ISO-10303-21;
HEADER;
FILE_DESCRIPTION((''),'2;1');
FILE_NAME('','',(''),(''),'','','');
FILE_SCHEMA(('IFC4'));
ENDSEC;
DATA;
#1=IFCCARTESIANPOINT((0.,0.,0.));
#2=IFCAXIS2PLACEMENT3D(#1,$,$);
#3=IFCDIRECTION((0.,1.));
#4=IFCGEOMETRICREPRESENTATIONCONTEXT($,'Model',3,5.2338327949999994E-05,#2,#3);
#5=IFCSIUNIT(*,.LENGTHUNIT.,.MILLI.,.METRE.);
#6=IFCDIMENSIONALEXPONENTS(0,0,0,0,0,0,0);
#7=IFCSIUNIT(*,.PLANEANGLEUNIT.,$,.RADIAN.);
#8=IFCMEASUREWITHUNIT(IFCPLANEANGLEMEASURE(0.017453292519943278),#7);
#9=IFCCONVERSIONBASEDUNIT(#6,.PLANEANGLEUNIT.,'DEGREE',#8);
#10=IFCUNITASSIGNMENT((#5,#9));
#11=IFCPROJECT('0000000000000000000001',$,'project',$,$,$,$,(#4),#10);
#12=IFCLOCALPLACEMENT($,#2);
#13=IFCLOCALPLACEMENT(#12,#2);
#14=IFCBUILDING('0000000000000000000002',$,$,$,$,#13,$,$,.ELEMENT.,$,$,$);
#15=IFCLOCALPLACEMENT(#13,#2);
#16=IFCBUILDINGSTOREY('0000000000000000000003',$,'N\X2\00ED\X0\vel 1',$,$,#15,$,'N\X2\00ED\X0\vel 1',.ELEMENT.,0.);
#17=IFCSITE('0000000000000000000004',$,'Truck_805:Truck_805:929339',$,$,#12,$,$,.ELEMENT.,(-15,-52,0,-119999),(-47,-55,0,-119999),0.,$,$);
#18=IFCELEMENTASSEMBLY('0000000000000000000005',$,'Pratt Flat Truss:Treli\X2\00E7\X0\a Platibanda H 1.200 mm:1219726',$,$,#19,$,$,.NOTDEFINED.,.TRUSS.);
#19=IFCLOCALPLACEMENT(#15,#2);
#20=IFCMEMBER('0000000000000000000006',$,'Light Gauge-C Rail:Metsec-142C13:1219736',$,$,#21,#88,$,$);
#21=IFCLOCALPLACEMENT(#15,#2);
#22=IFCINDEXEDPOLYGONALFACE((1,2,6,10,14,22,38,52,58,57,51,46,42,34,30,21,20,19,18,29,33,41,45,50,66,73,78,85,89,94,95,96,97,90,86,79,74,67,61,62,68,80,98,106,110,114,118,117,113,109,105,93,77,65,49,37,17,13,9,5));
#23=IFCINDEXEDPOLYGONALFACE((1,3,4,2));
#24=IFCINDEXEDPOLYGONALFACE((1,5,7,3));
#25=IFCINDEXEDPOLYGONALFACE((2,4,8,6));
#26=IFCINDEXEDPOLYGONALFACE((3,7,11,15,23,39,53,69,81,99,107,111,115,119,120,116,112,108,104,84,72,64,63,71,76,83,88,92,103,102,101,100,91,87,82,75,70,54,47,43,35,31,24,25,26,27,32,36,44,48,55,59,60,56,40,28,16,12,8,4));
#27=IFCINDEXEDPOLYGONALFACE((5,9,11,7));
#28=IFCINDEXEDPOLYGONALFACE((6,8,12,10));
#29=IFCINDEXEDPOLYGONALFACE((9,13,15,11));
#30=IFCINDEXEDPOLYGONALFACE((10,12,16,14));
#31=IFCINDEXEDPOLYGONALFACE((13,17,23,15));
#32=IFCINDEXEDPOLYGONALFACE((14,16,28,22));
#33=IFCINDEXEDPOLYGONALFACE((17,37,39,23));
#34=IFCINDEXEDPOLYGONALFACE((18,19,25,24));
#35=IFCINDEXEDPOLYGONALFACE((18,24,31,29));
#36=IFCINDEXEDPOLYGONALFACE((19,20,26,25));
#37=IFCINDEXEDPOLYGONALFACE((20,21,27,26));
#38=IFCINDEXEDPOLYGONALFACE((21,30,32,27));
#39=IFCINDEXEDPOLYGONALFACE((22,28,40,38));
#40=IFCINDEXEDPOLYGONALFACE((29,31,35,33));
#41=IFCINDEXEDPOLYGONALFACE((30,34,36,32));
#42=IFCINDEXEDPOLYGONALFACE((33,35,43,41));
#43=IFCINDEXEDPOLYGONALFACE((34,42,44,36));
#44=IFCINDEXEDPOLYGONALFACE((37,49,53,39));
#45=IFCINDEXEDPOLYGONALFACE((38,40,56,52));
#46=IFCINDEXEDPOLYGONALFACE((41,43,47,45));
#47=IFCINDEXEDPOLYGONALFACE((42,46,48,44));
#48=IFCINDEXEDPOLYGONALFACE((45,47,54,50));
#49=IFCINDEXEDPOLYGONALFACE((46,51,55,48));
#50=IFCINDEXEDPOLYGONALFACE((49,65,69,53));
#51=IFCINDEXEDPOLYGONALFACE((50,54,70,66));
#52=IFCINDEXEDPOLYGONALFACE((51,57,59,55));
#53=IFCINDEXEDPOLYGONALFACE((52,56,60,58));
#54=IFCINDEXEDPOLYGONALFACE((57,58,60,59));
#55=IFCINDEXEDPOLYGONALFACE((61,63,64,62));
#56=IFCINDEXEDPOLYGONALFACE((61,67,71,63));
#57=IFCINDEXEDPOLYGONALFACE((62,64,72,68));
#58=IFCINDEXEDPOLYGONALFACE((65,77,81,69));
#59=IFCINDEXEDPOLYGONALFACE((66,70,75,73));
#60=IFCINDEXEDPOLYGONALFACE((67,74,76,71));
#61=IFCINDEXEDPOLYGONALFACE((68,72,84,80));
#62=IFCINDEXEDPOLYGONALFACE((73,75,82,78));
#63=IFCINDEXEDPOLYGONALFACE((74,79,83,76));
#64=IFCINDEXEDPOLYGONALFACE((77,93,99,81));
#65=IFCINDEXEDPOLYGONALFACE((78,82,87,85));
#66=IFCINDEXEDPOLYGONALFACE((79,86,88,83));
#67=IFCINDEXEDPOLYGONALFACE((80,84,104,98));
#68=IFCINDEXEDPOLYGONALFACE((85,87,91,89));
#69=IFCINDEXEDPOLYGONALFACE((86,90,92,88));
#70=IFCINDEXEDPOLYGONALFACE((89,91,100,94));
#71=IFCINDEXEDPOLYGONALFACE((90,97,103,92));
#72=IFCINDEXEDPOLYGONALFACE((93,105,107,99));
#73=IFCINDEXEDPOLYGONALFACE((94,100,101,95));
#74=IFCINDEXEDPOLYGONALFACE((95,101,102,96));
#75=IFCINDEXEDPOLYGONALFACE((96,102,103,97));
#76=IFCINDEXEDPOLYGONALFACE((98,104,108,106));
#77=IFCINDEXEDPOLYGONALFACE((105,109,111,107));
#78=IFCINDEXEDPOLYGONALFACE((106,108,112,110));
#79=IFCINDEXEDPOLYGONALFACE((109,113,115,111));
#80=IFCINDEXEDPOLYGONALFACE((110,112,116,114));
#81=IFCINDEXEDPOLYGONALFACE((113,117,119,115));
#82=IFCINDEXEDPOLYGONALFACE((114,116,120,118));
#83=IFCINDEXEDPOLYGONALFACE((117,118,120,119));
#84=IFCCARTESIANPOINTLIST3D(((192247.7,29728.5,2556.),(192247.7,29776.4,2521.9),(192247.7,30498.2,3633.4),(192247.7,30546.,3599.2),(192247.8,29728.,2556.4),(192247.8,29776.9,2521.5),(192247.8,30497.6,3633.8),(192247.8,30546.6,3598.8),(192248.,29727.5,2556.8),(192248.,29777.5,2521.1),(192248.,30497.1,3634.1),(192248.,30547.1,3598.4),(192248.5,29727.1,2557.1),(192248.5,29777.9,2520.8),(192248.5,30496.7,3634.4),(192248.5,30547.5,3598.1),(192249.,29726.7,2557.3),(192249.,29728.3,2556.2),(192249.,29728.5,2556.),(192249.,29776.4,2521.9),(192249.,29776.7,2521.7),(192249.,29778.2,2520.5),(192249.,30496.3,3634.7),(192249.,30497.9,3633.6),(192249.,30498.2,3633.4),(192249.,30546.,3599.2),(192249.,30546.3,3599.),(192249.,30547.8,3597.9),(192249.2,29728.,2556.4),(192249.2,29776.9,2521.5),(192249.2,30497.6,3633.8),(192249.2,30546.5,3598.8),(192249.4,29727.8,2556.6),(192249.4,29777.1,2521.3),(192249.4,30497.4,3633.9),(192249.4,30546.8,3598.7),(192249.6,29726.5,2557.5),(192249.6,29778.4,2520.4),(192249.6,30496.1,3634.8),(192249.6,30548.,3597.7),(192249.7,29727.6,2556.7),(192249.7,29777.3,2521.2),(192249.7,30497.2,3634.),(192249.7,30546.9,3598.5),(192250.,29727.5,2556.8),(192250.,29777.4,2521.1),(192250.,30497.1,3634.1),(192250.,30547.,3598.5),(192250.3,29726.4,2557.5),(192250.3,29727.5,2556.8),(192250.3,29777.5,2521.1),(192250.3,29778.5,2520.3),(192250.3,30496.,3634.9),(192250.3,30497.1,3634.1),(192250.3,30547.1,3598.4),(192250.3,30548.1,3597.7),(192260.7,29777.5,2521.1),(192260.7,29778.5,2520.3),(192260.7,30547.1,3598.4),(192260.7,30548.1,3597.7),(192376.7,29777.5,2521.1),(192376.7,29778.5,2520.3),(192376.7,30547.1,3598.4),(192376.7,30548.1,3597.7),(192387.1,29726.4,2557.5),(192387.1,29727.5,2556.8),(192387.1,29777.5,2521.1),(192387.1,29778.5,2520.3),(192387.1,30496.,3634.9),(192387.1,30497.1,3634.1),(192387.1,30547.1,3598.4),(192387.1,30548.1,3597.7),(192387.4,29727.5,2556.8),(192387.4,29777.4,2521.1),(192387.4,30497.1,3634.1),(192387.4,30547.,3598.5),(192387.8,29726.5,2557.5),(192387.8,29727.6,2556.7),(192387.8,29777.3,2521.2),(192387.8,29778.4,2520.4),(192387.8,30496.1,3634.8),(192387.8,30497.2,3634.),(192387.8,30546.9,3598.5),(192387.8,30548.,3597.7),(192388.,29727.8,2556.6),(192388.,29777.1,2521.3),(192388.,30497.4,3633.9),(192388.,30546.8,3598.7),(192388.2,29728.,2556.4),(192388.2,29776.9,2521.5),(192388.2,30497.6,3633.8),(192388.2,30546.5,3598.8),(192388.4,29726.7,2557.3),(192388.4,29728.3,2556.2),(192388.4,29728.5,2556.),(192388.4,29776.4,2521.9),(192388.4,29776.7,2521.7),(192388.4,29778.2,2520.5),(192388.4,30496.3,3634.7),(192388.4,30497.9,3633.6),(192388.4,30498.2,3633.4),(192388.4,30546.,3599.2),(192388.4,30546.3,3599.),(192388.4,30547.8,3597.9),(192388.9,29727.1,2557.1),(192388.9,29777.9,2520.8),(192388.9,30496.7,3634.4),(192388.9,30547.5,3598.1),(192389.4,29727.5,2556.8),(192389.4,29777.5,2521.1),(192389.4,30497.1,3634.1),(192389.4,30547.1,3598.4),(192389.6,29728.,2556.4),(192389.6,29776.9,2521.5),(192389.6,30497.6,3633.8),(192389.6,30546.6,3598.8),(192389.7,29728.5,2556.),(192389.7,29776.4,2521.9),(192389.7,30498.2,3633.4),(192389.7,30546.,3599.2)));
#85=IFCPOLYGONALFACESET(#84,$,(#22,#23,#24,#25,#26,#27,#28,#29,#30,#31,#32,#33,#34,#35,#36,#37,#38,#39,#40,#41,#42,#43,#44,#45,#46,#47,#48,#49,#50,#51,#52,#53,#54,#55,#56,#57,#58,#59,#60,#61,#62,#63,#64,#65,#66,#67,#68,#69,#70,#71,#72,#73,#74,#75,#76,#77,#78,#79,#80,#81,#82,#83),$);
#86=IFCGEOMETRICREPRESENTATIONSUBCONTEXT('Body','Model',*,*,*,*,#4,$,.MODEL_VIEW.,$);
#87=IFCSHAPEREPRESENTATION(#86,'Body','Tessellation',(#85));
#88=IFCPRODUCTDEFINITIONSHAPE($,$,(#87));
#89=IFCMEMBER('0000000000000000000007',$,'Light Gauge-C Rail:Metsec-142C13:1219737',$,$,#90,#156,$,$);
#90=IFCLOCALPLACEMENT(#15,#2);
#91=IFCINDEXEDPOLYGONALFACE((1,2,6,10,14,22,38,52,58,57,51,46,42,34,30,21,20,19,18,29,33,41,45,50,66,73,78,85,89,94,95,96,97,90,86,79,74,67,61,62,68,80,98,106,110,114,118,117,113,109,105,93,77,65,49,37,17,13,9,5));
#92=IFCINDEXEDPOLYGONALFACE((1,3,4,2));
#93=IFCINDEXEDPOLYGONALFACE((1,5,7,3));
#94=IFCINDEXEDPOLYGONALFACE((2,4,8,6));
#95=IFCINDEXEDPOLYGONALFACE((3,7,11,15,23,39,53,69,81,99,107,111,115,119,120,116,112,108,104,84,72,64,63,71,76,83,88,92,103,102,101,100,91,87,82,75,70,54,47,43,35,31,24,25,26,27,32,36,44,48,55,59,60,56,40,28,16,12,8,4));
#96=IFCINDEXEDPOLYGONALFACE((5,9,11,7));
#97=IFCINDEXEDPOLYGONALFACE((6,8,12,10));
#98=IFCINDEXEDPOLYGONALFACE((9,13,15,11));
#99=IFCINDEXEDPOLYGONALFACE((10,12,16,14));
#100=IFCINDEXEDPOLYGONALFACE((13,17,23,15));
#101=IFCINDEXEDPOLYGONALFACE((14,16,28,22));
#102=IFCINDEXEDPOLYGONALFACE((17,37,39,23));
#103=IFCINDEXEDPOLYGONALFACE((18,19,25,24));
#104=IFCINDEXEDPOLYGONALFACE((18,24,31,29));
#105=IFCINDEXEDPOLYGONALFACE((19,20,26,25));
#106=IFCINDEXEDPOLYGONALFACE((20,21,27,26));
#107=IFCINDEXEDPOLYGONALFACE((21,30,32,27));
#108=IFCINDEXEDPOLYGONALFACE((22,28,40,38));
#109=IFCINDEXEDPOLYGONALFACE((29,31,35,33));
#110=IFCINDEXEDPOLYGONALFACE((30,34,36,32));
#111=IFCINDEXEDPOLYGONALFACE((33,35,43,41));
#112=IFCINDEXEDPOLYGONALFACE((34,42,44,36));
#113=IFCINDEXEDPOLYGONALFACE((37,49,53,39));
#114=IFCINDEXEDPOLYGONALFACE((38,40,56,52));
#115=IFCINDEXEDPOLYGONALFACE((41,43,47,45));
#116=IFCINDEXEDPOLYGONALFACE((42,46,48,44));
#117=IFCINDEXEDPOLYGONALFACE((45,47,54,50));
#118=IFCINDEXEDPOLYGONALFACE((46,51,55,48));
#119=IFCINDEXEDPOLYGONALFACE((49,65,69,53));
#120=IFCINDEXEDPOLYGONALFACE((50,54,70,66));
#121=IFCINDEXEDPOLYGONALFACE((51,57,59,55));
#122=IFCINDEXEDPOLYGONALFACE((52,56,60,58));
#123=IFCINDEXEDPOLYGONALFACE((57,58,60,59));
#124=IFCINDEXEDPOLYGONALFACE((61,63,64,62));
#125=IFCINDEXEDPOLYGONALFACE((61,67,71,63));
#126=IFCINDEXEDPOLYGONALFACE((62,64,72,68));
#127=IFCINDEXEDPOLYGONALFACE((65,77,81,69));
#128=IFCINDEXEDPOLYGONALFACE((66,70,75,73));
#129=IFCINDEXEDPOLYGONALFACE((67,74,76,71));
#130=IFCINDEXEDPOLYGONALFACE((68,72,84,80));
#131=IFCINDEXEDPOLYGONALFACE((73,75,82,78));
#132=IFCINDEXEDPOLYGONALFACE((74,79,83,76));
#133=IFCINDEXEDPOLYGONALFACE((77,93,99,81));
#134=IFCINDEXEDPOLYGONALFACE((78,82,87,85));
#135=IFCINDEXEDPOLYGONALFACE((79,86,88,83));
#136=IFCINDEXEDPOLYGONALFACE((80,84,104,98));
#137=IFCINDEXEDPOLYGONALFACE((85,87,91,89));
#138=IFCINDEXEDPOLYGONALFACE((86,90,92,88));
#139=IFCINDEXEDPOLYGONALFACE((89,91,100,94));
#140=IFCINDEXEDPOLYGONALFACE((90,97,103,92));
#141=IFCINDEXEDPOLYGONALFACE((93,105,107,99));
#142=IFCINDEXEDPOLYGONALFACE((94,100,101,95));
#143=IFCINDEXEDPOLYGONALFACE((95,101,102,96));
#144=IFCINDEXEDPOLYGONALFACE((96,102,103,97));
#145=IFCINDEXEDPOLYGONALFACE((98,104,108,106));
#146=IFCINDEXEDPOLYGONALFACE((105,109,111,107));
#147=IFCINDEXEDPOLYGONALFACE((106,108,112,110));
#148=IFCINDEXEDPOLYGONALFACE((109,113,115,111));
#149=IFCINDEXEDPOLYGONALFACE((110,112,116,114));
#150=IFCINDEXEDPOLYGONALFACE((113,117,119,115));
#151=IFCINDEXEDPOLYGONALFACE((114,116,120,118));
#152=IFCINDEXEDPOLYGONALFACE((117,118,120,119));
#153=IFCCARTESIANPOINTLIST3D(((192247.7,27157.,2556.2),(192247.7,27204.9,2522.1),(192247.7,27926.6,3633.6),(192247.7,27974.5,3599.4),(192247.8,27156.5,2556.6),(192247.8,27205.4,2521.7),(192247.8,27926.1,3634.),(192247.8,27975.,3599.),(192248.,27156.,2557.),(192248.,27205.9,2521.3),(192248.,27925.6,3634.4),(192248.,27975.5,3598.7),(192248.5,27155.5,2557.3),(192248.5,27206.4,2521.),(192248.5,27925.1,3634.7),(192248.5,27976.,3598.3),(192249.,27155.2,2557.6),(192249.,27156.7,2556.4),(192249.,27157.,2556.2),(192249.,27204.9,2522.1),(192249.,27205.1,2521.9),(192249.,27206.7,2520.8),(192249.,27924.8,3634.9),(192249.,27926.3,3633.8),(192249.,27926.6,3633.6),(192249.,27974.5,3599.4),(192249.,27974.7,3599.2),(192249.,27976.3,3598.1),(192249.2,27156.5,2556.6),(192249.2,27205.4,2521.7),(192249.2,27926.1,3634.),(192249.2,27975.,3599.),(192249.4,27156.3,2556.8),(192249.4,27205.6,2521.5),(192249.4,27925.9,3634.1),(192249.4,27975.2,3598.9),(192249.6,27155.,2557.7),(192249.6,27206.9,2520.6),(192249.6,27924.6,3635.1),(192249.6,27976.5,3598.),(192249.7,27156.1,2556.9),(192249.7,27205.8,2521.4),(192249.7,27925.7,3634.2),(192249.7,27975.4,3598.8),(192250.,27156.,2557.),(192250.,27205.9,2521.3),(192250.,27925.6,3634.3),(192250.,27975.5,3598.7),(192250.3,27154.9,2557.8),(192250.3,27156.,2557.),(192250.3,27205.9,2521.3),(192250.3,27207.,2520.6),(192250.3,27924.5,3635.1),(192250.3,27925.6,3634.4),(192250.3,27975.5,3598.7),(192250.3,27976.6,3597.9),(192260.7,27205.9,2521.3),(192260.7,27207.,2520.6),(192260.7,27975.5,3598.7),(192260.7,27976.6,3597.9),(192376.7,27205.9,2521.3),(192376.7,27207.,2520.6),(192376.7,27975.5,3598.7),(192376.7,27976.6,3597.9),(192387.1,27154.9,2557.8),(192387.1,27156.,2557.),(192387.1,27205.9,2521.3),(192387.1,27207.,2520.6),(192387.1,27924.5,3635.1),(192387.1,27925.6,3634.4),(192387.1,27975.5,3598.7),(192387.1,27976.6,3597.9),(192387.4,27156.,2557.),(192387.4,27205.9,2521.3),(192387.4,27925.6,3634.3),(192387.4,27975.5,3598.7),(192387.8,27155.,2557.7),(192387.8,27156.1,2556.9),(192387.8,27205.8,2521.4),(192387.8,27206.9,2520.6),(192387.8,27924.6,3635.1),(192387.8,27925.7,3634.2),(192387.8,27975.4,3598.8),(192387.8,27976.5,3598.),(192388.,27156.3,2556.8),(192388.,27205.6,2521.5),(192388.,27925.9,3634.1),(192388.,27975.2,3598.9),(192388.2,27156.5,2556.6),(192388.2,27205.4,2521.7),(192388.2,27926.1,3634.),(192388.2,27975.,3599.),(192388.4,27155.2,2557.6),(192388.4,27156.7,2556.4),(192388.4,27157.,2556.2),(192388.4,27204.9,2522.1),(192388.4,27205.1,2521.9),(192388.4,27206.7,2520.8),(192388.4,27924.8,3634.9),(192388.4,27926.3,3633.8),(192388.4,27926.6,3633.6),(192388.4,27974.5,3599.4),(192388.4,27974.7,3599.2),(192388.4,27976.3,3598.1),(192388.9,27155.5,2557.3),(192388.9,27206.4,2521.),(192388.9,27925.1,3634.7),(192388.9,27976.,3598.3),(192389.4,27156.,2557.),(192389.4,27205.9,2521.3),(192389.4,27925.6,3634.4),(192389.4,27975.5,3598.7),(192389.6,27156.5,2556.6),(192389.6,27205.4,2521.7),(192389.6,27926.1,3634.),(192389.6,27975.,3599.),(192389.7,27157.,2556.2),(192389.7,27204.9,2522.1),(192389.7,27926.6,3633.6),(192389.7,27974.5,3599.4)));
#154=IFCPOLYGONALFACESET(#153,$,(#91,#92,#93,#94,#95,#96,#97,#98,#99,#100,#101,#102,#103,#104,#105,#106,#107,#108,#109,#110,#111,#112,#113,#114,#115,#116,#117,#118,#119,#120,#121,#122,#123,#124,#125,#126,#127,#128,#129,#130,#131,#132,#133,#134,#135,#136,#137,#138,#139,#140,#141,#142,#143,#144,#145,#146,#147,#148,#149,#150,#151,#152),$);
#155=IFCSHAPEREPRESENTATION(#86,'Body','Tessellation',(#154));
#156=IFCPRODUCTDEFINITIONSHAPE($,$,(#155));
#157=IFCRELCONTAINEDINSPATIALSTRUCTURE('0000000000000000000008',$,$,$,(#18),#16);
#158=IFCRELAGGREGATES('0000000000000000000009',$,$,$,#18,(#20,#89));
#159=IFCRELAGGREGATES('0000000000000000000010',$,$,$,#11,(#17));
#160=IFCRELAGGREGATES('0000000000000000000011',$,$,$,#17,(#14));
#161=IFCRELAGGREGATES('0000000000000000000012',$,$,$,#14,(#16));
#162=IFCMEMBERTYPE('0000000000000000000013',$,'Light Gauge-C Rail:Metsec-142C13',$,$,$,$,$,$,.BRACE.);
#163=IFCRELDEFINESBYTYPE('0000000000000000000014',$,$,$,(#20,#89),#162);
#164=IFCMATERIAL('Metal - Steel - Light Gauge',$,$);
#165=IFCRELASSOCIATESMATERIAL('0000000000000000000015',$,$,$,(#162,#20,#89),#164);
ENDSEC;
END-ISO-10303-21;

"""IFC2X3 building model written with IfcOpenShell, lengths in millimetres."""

from ifc_helpers import new_model, entity, si_unit, converted_unit, direction, frame, frame_2d, origin, place, context, subcontext, project, spatial, polyline, circle_curve, parameter, trimmed, segment, composite_curve, outline, extrude, source, transform, mapped, material, type_object, type_shapes, element, aggregate, save


model = new_model("IFC2X3")

# Units and contexts
model_context = context("Model", 3, precision=5.2338327949999994e-05, world=origin(), true_north=direction((0.0, 1.0)))
body_context = subcontext(model_context, "Body", "Model", "MODEL_VIEW")
ifc_project = project(units=[si_unit("LENGTHUNIT", "METRE", prefix="MILLI"), converted_unit("PLANEANGLEUNIT", "DEGREE", entity("IfcPlaneAngleMeasure", 0.017453292519943278), si_unit("PLANEANGLEUNIT", "RADIAN"), dimensions=[0, 0, 0, 0, 0, 0, 0])], contexts=[model_context])

# Site, building, storey
site_placement = place(None, origin())
site = spatial("IfcSite", under=ifc_project, at=site_placement, Name="Truck_805:Truck_805:929339", CompositionType="ELEMENT", RefLatitude=(-15, -52, 0, -119999), RefLongitude=(-47, -55, 0, -119999), RefElevation=0.0)
building_placement = place(site_placement, origin())
building = spatial("IfcBuilding", under=site, at=building_placement, CompositionType="ELEMENT")
storey_placement = place(building_placement, origin())
storey = spatial("IfcBuildingStorey", under=building, at=storey_placement, Name="Nível 1", LongName="Nível 1", CompositionType="ELEMENT", Elevation=0.0)

# Element assembly, members
assembly_1_placement = place(storey_placement, origin())
assembly_1 = element("IfcElementAssembly", 1, at=assembly_1_placement, inside=storey, Name="Pratt Flat Truss:Treliça Platibanda H 1.200 mm:1219726", AssemblyPlace="NOTDEFINED", PredefinedType="TRUSS")
ifc_material_1 = material(Name="Metal - Steel - Light Gauge")
member_type_1 = type_object("IfcMemberType", Name="Light Gauge-C Rail:Metsec-142C13", PredefinedType="BRACE", material=ifc_material_1)
shared_shape_1 = source(origin(), body_context, "Body", "SweptSolid", [
    extrude(outline(composite_curve([segment(polyline([(-23.1, -71.0), (35.7, -71.0)]), True, "CONTINUOUS"), segment(trimmed(circle_curve(frame_2d((35.7, -68.4), x_axis=(0.0, -1.0)), 2.6), [parameter(0.0)], [parameter(90.0)], True, "PARAMETER"), True, "CONTINUOUS"), segment(polyline([(38.3, -68.4), (38.3, 68.4)]), True, "CONTINUOUS"), segment(trimmed(circle_curve(frame_2d((35.7, 68.4), x_axis=(1.0, 0.0)), 2.6), [parameter(0.0)], [parameter(90.0)], True, "PARAMETER"), True, "CONTINUOUS"), segment(polyline([(35.7, 71.0), (-23.1, 71.0)]), True, "CONTINUOUS"), segment(trimmed(circle_curve(frame_2d((-23.1, 68.4), x_axis=(0.0, 1.0)), 2.6), [parameter(0.0)], [parameter(90.0)], True, "PARAMETER"), True, "CONTINUOUS"), segment(polyline([(-25.7, 68.4), (-25.7, 58.0)]), True, "CONTINUOUS"), segment(polyline([(-25.7, 58.0), (-24.4, 58.0)]), True, "CONTINUOUS"), segment(polyline([(-24.4, 58.0), (-24.4, 68.4)]), True, "CONTINUOUS"), segment(trimmed(circle_curve(frame_2d((-23.1, 68.4), x_axis=(-1.0, 0.0)), 1.3), [parameter(270.0)], [parameter(0.0)], True, "PARAMETER"), False, "CONTINUOUS"), segment(polyline([(-23.1, 69.7), (35.7, 69.7)]), True, "CONTINUOUS"), segment(trimmed(circle_curve(frame_2d((35.7, 68.4), x_axis=(0.0, 1.0)), 1.3), [parameter(270.0)], [parameter(0.0)], True, "PARAMETER"), False, "CONTINUOUS"), segment(polyline([(37.0, 68.4), (37.0, -68.4)]), True, "CONTINUOUS"), segment(trimmed(circle_curve(frame_2d((35.7, -68.4), x_axis=(1.0, 0.0)), 1.3), [parameter(270.0)], [parameter(0.0)], True, "PARAMETER"), False, "CONTINUOUS"), segment(polyline([(35.7, -69.7), (-23.1, -69.7)]), True, "CONTINUOUS"), segment(trimmed(circle_curve(frame_2d((-23.1, -68.4), x_axis=(0.0, -1.0)), 1.3), [parameter(270.0)], [parameter(0.0)], True, "PARAMETER"), False, "CONTINUOUS"), segment(polyline([(-24.4, -68.4), (-24.4, -58.0)]), True, "CONTINUOUS"), segment(polyline([(-24.4, -58.0), (-25.7, -58.0)]), True, "CONTINUOUS"), segment(polyline([(-25.7, -58.0), (-25.7, -68.4)]), True, "CONTINUOUS"), segment(trimmed(circle_curve(frame_2d((-23.1, -68.4), x_axis=(-1.0, 0.0)), 2.6), [parameter(0.0)], [parameter(90.0)], True, "PARAMETER"), True, "CONTINUOUS")], self_intersect=False)), frame((-671.0, 0.0, 18.8), z_axis=(1.0, 0.0, 0.0), x_axis=(0.0, 0.0, -1.0)), (0.0, 0.0, 1.0), 1324.0),
])
type_shapes(member_type_1, [shared_shape_1])
member_1_placement = place(assembly_1_placement, frame((192318.7, 30121.9, 3077.6), z_axis=(0.0, 0.813705, -0.581278), x_axis=(0.0, -0.581278, -0.813705)))
member_1 = element("IfcMember", 2, at=member_1_placement, type_object=member_type_1, material=ifc_material_1, Name="Light Gauge-C Rail:Metsec-142C13:1219736", context=body_context, shape_type="MappedRepresentation", body=[
    mapped(shared_shape_1, transform((0.0, 0.0, 0.0), scale=1.0)),
])
member_2_placement = place(assembly_1_placement, frame((192318.7, 27550.3, 3077.8), z_axis=(0.0, 0.813705, -0.581278), x_axis=(0.0, -0.581278, -0.813705)))
member_2 = element("IfcMember", 3, at=member_2_placement, type_object=member_type_1, material=ifc_material_1, Name="Light Gauge-C Rail:Metsec-142C13:1219737", context=body_context, shape_type="MappedRepresentation", body=[
    mapped(shared_shape_1, transform((0.0, 0.0, 0.0), scale=1.0)),
])
aggregate(assembly_1, [member_1, member_2])

save(model, "model.ifc")
